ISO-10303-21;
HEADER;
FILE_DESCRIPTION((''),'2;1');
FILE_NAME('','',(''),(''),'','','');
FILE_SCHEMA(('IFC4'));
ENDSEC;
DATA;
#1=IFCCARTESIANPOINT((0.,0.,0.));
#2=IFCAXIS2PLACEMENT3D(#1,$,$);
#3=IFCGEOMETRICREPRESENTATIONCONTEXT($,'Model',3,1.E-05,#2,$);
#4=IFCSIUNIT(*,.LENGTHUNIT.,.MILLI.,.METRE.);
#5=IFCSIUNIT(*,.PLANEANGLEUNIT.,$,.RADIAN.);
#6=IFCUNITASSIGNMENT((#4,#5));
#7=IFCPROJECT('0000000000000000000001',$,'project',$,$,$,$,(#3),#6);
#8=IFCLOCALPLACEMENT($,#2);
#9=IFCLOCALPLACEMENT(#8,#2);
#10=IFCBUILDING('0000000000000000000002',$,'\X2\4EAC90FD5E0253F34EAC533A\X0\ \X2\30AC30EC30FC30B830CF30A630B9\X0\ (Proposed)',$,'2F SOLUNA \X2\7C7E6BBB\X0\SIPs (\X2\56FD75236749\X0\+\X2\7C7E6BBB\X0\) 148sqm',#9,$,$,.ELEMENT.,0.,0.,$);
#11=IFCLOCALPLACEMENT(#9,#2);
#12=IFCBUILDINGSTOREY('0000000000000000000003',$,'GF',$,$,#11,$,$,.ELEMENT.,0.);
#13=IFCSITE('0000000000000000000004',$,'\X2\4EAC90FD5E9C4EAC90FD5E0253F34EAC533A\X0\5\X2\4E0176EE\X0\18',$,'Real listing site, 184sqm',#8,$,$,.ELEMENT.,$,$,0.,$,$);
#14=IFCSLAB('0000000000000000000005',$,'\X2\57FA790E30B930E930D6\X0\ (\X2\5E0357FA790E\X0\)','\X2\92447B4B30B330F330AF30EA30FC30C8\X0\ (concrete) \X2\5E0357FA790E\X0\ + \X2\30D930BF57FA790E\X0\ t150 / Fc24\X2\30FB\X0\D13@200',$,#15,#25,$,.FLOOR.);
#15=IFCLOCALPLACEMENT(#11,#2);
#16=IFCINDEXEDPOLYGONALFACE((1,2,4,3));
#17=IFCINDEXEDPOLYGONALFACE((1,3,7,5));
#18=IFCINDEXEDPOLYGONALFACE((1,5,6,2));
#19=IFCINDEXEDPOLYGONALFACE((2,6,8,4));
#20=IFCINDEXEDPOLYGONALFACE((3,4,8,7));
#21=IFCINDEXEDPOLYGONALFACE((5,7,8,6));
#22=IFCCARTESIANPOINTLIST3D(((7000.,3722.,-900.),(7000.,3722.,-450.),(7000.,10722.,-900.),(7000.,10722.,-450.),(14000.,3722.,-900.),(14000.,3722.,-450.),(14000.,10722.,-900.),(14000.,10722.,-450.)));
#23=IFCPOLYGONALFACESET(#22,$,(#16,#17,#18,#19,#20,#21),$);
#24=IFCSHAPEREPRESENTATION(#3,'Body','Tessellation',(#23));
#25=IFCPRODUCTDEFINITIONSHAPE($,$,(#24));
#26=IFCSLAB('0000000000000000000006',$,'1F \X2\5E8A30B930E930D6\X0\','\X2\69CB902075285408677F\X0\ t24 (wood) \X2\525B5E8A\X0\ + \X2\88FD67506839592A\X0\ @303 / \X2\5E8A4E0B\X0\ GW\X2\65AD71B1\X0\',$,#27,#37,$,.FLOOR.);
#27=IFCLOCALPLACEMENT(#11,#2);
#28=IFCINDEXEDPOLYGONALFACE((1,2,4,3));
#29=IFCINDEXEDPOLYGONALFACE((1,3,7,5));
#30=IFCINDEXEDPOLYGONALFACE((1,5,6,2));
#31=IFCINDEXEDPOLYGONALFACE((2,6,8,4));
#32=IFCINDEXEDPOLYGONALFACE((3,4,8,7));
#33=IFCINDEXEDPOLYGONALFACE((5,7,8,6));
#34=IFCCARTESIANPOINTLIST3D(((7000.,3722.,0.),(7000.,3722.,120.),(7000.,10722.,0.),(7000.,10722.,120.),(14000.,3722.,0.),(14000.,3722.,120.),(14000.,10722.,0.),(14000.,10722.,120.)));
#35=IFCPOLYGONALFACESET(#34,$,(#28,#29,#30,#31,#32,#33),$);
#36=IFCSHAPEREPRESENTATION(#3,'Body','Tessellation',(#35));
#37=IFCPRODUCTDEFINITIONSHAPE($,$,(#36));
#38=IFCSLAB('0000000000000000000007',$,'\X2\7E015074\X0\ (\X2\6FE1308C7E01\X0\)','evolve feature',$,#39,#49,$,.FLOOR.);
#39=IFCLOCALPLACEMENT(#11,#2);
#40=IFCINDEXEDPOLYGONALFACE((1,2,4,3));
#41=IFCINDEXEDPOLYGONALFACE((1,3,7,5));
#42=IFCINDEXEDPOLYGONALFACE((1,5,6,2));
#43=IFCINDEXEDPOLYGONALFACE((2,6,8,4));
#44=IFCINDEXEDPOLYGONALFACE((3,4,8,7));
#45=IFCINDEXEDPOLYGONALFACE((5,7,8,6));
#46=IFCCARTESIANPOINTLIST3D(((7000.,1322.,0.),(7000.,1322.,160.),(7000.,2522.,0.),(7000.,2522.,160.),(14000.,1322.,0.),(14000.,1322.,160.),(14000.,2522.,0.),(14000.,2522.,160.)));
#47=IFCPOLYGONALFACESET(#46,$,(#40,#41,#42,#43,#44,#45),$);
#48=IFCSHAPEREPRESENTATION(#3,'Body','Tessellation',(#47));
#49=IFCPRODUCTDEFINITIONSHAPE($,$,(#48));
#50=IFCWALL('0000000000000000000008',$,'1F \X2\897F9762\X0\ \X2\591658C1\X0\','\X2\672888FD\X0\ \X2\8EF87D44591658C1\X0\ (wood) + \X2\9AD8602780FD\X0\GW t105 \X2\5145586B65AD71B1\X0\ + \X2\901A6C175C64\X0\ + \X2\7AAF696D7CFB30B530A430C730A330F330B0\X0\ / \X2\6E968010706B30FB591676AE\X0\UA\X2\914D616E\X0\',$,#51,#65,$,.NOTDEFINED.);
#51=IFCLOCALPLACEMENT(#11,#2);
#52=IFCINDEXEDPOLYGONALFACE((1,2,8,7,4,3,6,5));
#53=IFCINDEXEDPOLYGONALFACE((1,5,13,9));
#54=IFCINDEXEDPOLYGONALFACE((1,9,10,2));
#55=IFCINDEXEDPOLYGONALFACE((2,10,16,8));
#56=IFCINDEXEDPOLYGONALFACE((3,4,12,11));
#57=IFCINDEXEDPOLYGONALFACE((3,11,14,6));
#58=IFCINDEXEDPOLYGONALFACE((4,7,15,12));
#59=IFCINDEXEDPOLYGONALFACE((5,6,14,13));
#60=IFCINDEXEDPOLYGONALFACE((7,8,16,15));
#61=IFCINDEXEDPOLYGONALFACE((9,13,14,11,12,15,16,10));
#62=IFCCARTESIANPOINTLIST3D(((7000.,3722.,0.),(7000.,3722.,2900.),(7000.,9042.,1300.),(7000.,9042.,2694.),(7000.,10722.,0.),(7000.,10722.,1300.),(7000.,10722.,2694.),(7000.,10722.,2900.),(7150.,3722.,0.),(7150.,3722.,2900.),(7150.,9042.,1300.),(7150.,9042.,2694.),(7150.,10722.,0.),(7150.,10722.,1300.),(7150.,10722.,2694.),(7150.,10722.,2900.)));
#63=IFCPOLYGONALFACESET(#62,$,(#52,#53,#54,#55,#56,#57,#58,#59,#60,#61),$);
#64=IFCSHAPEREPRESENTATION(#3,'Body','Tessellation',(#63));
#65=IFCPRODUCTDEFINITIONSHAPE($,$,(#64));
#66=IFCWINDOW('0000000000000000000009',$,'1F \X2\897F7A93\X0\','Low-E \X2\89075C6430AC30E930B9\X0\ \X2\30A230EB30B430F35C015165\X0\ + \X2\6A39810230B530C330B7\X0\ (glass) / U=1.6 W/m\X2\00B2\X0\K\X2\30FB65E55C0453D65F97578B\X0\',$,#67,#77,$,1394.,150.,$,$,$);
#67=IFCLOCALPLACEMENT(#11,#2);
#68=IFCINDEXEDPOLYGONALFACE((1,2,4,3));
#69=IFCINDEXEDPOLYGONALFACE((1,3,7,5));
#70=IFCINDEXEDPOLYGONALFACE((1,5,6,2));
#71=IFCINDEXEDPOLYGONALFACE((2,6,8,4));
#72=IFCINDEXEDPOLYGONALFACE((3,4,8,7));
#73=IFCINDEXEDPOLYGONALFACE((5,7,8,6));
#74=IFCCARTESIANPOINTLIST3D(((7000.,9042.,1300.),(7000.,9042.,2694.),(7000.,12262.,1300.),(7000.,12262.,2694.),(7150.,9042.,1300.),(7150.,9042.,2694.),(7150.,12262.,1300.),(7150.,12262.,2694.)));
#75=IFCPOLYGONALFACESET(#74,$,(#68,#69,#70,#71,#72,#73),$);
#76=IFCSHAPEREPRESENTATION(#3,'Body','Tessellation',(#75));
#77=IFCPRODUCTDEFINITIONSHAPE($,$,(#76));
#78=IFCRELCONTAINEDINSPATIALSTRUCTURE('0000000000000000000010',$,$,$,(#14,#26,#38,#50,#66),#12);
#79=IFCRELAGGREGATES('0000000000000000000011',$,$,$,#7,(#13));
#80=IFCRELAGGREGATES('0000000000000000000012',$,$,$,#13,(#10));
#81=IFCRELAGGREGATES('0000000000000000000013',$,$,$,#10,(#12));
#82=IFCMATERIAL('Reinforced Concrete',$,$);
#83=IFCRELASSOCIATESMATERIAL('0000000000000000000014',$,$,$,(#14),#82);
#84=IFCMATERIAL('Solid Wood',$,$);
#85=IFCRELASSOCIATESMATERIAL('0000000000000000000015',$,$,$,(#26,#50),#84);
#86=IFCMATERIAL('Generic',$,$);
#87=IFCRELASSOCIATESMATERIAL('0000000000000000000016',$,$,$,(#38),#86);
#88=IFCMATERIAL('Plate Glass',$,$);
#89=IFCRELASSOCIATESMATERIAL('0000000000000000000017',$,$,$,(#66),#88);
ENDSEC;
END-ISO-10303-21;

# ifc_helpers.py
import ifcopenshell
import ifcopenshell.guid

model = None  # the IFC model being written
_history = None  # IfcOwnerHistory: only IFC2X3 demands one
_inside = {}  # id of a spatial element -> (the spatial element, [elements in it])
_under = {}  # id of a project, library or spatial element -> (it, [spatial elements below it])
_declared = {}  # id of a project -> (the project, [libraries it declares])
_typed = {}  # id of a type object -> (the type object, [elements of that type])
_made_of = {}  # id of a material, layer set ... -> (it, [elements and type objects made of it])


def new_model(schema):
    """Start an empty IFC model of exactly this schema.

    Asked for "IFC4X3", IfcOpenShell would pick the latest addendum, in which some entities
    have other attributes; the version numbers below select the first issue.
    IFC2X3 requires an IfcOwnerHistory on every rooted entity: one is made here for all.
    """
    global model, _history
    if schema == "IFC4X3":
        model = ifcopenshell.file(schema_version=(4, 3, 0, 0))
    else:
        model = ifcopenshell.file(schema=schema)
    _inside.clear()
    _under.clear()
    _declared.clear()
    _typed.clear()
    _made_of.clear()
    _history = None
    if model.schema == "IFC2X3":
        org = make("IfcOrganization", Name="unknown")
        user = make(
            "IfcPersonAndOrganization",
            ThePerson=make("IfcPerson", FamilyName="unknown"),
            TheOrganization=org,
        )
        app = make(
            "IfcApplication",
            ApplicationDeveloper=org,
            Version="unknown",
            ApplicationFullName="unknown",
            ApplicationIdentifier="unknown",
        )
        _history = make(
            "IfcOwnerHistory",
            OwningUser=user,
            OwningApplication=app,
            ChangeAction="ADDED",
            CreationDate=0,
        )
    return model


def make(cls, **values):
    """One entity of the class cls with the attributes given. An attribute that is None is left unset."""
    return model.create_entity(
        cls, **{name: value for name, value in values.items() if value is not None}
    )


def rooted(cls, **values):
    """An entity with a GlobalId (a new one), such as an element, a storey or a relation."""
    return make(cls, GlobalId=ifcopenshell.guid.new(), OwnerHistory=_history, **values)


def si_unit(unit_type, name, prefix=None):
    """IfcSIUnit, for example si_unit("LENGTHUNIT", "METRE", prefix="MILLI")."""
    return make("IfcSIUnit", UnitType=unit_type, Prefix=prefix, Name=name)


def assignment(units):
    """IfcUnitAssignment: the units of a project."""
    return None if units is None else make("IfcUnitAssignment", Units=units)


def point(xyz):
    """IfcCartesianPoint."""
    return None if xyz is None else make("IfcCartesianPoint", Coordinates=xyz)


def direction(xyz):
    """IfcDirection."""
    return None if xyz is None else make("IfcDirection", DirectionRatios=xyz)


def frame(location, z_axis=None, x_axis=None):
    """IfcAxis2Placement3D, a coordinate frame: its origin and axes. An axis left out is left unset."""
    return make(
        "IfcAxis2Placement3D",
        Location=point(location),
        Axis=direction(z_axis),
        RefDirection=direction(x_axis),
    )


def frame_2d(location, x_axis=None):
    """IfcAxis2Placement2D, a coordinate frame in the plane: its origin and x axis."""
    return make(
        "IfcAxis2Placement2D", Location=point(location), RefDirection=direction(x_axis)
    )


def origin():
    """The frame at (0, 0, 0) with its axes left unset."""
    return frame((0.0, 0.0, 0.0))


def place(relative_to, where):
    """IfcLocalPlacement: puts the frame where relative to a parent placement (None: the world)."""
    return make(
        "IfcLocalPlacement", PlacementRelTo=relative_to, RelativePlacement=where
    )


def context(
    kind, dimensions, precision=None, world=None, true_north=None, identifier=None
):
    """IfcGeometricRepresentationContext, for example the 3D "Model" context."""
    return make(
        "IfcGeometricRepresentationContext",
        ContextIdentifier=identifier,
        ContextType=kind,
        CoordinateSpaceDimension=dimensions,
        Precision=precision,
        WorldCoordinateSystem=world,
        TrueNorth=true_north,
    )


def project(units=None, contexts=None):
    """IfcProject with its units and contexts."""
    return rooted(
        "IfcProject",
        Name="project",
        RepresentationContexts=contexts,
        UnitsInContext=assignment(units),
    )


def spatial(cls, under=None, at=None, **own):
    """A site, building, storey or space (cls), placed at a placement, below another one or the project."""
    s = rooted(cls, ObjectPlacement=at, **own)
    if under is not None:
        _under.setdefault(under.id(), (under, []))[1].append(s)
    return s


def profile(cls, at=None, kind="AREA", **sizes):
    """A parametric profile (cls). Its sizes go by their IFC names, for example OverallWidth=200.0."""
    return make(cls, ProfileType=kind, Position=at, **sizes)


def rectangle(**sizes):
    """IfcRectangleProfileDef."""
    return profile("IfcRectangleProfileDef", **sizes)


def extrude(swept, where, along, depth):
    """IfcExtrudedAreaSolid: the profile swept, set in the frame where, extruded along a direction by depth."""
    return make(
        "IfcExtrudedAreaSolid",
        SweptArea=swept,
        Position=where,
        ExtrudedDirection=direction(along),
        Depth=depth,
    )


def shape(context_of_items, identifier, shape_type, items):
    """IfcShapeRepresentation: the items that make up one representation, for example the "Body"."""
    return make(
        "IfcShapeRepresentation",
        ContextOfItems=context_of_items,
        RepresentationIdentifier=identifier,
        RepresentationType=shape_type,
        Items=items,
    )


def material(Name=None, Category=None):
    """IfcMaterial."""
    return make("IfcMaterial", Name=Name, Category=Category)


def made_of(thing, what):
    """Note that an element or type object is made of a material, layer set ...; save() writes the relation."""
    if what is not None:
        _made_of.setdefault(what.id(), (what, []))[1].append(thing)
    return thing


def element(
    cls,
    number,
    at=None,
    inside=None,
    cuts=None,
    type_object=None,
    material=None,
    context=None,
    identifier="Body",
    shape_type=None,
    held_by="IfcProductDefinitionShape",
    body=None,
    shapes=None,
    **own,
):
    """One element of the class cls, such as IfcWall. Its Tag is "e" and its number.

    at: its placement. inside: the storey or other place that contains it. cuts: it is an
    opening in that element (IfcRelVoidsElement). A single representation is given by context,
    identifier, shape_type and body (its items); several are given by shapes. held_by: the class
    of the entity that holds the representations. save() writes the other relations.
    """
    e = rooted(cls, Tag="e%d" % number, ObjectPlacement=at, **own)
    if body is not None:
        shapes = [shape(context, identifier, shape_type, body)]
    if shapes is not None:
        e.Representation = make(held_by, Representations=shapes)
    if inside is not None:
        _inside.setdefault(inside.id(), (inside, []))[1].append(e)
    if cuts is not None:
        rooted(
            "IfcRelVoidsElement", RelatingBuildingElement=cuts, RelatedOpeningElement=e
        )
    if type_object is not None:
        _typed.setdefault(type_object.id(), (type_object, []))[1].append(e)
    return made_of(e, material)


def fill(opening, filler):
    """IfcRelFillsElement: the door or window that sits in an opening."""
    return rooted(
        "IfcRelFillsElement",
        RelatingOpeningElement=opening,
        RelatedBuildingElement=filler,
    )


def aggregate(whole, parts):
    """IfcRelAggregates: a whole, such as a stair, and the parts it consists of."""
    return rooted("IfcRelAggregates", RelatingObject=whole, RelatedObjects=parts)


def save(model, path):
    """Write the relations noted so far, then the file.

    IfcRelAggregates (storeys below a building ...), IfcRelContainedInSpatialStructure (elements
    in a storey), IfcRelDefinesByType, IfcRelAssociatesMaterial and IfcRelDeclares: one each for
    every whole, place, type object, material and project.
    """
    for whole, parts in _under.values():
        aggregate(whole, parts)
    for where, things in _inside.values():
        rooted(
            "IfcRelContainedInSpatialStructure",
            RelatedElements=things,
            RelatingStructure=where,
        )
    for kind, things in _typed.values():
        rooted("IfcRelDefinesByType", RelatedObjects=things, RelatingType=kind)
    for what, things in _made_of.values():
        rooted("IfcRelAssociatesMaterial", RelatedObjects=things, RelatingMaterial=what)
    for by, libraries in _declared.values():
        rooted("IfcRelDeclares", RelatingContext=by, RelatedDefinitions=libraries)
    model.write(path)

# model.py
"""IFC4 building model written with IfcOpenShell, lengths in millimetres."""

from ifc_helpers import new_model, si_unit, frame, frame_2d, origin, place, context, project, spatial, rectangle, extrude, material, element, fill, save


model = new_model("IFC4")

# Units and contexts
model_context = context("Model", 3, precision=1e-05, world=origin())
ifc_project = project(units=[si_unit("LENGTHUNIT", "METRE", prefix="MILLI"), si_unit("PLANEANGLEUNIT", "RADIAN")], contexts=[model_context])

# Site, building, storey
site_placement = place(None, origin())
site = spatial("IfcSite", under=ifc_project, at=site_placement, Name="京都府京都市右京区5丁目18", ObjectType="Real listing site, 184sqm", CompositionType="ELEMENT", RefElevation=0.0)
building_placement = place(site_placement, origin())
building = spatial("IfcBuilding", under=site, at=building_placement, Name="京都市右京区 ガレージハウス (Proposed)", ObjectType="2F SOLUNA 籾殻SIPs (国産杉+籾殻) 148sqm", CompositionType="ELEMENT", ElevationOfRefHeight=0.0, ElevationOfTerrain=0.0)
storey_placement = place(building_placement, origin())
storey = spatial("IfcBuildingStorey", under=building, at=storey_placement, Name="GF", CompositionType="ELEMENT", Elevation=0.0)

# Slabs
ifc_material_1 = material(Name="Reinforced Concrete")
slab_1_placement = place(storey_placement, frame((3500.0, 1861.0, -450.0)))
element("IfcSlab", 1, at=slab_1_placement, inside=storey, material=ifc_material_1, Name="基礎スラブ (布基礎)", Description="鉄筋コンクリート (concrete) 布基礎 + ベタ基礎 t150 / Fc24・D13@200", PredefinedType="FLOOR", context=model_context, shape_type="SweptSolid", body=[
    extrude(rectangle(XDim=7000.0, YDim=7000.0, at=frame_2d((3500.0, 3500.0))), frame((3500.0, 1861.0, -450.0)), (0.0, 0.0, 1.0), 450.0),
])
ifc_material_2 = material(Name="Solid Wood")
slab_2_placement = place(storey_placement, frame((3500.0, 1861.0, 0.0)))
element("IfcSlab", 2, at=slab_2_placement, inside=storey, material=ifc_material_2, Name="1F 床スラブ", Description="構造用合板 t24 (wood) 剛床 + 製材根太 @303 / 床下 GW断熱", PredefinedType="FLOOR", context=model_context, shape_type="SweptSolid", body=[
    extrude(rectangle(XDim=7000.0, YDim=7000.0, at=frame_2d((3500.0, 3500.0))), frame((3500.0, 1861.0, 0.0)), (0.0, 0.0, 1.0), 120.0),
])
ifc_material_3 = material(Name="Generic")
slab_3_placement = place(storey_placement, frame((3500.0, 661.0, 0.0)))
element("IfcSlab", 3, at=slab_3_placement, inside=storey, material=ifc_material_3, Name="縁側 (濡れ縁)", Description="evolve feature", PredefinedType="FLOOR", context=model_context, shape_type="SweptSolid", body=[
    extrude(rectangle(XDim=7000.0, YDim=1200.0, at=frame_2d((3500.0, 600.0))), frame((3500.0, 661.0, 0.0)), (0.0, 0.0, 1.0), 160.0),
])

# Shared definitions
ifc_material_4 = material(Name="Plate Glass")

# Wall, opening, window
wall_1_placement = place(storey_placement, frame((3500.0, 1861.0, 0.0)))
wall_1 = element("IfcWall", 4, at=wall_1_placement, inside=storey, material=ifc_material_2, Name="1F 西面 外壁", Description="木製 軸組外壁 (wood) + 高性能GW t105 充填断熱 + 通気層 + 窯業系サイディング / 準耐火・外皮UA配慮", PredefinedType="NOTDEFINED", context=model_context, shape_type="SweptSolid", body=[
    extrude(rectangle(XDim=150.0, YDim=7000.0, at=frame_2d((75.0, 3500.0))), frame((3500.0, 1861.0, 0.0)), (0.0, 0.0, 1.0), 2900.0),
])
opening_1_placement = place(storey_placement, frame((3500.0, 4521.0, 650.0)))
opening_1 = element("IfcOpeningElement", 5, at=opening_1_placement, cuts=wall_1, PredefinedType="NOTDEFINED", context=model_context, shape_type="SweptSolid", body=[
    extrude(rectangle(XDim=150.0, YDim=3220.0, at=frame_2d((75.0, 1610.0))), frame((3500.0, 4521.0, 650.0)), (0.0, 0.0, 1.0), 1394.0),
])
window_1_placement = place(storey_placement, frame((3500.0, 4521.0, 650.0)))
window_1 = element("IfcWindow", 6, at=window_1_placement, inside=storey, material=ifc_material_4, Name="1F 西窓", Description="Low-E 複層ガラス アルゴン封入 + 樹脂サッシ (glass) / U=1.6 W/m²K・日射取得型", OverallHeight=1394.0, OverallWidth=150.0, context=model_context, shape_type="SweptSolid", body=[
    extrude(rectangle(XDim=150.0, YDim=3220.0, at=frame_2d((75.0, 1610.0))), frame((3500.0, 4521.0, 650.0)), (0.0, 0.0, 1.0), 1394.0),
])
fill(opening_1, window_1)

save(model, "model.ifc")
